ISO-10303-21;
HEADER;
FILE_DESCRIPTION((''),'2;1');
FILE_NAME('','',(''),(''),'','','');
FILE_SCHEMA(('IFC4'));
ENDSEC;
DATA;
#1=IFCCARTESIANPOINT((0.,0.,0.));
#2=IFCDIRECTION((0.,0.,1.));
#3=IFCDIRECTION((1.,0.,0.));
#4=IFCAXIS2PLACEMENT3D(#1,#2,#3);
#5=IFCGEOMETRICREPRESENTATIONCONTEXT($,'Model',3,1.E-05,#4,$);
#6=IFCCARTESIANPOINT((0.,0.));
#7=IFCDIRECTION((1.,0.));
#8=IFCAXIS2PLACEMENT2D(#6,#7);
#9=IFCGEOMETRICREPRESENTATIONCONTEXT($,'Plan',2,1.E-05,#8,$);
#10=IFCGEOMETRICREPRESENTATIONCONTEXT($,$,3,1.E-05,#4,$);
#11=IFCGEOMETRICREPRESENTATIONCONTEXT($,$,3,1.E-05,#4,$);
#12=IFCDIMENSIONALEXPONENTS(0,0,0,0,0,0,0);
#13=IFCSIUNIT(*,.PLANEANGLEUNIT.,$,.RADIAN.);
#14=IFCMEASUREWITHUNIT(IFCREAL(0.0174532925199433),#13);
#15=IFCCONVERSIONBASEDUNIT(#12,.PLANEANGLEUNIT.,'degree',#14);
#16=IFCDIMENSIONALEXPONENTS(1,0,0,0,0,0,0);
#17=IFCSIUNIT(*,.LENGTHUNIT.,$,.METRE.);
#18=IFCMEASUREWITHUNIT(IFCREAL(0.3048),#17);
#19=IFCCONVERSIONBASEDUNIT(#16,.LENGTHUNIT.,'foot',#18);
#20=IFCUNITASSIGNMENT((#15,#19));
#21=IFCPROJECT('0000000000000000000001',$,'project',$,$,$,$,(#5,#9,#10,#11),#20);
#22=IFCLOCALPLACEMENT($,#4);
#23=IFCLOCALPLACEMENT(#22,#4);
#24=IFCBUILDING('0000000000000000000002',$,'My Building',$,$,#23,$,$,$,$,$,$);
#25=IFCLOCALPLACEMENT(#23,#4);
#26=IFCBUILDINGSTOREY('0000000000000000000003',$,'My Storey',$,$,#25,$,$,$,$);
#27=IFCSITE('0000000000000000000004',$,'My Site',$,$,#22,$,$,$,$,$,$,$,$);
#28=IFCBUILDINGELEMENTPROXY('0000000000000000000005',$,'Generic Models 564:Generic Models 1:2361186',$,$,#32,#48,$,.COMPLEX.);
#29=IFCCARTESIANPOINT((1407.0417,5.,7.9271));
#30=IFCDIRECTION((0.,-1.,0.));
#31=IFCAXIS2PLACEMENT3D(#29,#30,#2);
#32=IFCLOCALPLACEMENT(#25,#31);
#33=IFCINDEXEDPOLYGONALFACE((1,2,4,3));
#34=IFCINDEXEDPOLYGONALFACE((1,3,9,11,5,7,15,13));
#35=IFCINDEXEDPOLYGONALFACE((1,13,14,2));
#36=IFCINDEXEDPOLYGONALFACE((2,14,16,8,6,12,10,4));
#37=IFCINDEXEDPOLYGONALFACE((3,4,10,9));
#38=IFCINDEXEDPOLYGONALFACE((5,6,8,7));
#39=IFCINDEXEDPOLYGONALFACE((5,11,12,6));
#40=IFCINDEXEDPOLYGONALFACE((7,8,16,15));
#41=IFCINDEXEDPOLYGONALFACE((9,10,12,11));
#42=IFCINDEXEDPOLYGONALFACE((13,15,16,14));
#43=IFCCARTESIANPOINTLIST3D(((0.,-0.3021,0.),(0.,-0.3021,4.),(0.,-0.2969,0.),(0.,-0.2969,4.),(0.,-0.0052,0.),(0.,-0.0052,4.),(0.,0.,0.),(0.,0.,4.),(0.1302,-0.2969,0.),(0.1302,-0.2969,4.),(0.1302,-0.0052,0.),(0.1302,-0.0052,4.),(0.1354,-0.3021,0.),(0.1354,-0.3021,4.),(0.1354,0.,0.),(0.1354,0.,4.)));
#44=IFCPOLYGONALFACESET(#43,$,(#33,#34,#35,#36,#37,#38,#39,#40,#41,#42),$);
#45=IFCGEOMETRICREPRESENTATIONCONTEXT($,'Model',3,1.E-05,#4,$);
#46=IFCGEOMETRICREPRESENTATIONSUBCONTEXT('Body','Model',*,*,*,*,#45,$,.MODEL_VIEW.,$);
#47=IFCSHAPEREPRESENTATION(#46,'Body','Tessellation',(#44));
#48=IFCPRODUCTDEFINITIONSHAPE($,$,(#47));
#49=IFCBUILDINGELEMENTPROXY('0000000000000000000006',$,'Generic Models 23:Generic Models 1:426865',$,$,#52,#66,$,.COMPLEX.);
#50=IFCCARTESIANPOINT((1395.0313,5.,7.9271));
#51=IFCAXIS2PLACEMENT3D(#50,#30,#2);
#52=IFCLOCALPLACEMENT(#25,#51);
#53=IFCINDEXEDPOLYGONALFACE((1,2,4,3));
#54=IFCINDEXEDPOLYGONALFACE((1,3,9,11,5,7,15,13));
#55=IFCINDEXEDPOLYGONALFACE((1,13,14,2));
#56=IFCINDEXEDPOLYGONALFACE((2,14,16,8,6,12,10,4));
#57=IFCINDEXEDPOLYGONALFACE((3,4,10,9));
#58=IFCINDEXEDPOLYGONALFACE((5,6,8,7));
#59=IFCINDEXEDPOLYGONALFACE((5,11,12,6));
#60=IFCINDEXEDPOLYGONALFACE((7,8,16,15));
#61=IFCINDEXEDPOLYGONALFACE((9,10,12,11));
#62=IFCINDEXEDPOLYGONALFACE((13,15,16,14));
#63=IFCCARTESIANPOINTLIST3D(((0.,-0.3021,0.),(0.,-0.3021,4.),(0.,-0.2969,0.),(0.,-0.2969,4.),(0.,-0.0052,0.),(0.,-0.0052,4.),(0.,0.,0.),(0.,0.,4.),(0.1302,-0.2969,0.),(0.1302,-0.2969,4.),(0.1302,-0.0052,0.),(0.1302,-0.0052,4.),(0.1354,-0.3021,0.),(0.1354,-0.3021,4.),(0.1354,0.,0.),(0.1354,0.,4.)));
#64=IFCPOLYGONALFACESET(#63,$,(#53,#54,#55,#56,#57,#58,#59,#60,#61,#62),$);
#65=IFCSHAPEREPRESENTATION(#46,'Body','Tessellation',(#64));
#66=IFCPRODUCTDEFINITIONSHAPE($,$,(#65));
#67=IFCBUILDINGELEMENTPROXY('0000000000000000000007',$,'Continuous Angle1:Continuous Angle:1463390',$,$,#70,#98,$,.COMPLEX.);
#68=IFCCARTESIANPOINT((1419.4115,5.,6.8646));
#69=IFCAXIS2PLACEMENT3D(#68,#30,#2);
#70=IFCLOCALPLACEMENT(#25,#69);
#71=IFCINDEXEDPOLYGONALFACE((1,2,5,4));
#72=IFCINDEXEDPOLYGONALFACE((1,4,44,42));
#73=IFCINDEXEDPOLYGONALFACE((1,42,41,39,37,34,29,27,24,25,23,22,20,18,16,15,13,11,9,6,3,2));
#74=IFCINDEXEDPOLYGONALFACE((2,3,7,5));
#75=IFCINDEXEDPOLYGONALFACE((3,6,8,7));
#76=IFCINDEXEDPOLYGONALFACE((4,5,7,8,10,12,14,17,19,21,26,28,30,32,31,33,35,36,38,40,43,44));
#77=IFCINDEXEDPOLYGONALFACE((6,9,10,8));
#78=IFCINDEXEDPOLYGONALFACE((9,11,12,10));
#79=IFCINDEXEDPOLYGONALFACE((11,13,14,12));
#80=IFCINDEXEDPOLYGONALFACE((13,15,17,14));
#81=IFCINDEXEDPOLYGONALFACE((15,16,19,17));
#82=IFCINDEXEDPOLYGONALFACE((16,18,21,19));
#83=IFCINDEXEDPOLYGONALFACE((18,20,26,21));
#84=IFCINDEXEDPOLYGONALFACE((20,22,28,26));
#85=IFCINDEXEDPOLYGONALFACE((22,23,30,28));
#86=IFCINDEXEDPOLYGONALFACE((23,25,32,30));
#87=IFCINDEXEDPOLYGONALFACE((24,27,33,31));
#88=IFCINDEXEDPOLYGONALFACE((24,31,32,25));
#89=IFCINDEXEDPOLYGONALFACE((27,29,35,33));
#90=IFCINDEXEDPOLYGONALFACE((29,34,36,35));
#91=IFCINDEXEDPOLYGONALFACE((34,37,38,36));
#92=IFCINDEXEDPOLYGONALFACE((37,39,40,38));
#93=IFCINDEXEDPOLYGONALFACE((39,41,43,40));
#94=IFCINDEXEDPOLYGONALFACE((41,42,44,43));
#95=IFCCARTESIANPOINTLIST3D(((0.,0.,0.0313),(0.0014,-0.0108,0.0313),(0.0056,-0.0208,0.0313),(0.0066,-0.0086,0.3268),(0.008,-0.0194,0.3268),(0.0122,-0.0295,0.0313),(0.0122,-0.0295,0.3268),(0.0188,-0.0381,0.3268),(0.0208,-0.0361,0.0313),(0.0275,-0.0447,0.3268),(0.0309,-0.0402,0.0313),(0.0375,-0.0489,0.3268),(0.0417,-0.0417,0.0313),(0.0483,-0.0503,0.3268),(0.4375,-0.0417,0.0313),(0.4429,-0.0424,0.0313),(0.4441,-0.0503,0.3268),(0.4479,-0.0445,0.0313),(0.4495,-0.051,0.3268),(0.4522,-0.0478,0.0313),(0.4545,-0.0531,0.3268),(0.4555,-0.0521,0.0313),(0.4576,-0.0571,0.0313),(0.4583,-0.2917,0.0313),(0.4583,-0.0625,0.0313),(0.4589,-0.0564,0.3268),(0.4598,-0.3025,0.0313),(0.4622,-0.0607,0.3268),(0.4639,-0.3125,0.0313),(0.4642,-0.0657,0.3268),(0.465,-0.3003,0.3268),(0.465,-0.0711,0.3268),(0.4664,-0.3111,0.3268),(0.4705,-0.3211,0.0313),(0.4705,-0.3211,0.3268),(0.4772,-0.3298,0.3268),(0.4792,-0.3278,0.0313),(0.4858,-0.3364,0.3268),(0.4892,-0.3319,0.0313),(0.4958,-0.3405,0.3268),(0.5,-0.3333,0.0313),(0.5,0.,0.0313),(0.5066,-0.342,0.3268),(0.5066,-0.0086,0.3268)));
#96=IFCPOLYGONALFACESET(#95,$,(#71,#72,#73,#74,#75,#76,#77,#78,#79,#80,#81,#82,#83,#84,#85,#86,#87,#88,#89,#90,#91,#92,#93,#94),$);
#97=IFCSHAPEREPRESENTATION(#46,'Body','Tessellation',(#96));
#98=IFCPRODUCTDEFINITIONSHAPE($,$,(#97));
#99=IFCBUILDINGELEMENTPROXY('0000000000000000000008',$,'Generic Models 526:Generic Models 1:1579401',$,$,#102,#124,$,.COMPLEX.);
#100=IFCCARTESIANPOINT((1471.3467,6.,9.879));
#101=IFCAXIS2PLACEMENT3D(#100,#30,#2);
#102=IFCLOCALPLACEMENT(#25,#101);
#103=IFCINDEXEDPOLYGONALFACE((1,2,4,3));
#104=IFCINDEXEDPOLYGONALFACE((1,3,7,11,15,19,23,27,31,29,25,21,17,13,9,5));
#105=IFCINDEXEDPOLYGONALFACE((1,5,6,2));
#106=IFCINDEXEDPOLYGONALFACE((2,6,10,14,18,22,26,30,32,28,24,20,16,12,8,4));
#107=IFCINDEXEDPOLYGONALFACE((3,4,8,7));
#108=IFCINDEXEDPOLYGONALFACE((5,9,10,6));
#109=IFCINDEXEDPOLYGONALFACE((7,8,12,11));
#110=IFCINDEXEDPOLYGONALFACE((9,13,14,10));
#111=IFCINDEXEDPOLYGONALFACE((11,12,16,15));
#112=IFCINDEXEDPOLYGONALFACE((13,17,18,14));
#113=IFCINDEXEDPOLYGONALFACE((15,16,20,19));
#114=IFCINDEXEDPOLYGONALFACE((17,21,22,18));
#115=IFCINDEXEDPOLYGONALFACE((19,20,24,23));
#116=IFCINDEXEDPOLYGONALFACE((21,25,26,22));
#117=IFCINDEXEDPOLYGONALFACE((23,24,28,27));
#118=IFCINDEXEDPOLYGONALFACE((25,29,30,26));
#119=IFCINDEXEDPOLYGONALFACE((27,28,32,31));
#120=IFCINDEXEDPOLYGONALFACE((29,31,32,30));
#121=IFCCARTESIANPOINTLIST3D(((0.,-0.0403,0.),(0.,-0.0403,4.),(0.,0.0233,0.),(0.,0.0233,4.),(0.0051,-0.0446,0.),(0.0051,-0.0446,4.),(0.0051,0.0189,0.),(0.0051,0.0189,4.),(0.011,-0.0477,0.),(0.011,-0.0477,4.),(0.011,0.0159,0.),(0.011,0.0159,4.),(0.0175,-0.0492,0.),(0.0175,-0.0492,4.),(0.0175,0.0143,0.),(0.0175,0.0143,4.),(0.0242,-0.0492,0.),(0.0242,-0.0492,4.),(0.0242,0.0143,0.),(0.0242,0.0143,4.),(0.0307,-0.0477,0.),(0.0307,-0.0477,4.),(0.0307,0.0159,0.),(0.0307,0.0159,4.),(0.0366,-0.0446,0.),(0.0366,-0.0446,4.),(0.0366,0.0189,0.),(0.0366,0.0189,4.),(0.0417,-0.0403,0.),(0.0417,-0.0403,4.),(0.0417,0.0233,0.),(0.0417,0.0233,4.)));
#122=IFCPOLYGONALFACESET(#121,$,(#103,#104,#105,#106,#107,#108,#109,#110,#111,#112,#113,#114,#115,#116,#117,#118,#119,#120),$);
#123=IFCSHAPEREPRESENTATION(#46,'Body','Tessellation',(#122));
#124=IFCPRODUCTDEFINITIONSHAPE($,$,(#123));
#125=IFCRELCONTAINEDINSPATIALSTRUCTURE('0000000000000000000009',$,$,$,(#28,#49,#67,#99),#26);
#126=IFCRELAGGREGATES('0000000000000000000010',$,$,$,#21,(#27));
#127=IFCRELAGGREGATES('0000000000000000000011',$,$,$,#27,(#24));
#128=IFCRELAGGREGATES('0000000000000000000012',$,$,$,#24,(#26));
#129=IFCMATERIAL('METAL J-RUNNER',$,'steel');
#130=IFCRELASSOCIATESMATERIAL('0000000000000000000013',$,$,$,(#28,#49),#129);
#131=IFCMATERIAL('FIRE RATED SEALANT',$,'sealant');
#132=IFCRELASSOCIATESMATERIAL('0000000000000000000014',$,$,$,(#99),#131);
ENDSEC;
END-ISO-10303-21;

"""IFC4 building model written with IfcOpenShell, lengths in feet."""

from ifc_helpers import new_model, entity, si_unit, converted_unit, frame, origin_with_axes, origin_2d_with_axis, place, context, subcontext, project, spatial, polyline, line, indexed_curve, outline, extrude, material, element, save


model = new_model("IFC4")

# Units and contexts
model_context_1 = context("Model", 3, precision=1e-05, world=origin_with_axes())
plan_context = context("Plan", 2, precision=1e-05, world=origin_2d_with_axis())
model_context_2 = context("Model", 3, precision=1e-05, world=origin_with_axes())
context_of_model_1 = context(None, 3, precision=1e-05, world=origin_with_axes())
context_of_model_2 = context(None, 3, precision=1e-05, world=origin_with_axes())
body_context_1 = subcontext(model_context_2, "Body", "Model", "MODEL_VIEW")
ifc_project = project(units=[converted_unit("PLANEANGLEUNIT", "degree", entity("IfcReal", 0.0174532925199433), si_unit("PLANEANGLEUNIT", "RADIAN"), dimensions=[0, 0, 0, 0, 0, 0, 0]), converted_unit("LENGTHUNIT", "foot", entity("IfcReal", 0.3048), si_unit("LENGTHUNIT", "METRE"), dimensions=[1, 0, 0, 0, 0, 0, 0])], contexts=[model_context_1, plan_context, context_of_model_1, context_of_model_2])

# Site, building, storey
site_placement = place(None, origin_with_axes())
site = spatial("IfcSite", under=ifc_project, at=site_placement, Name="My Site")
building_placement = place(site_placement, origin_with_axes())
building = spatial("IfcBuilding", under=site, at=building_placement, Name="My Building")
storey_placement = place(building_placement, origin_with_axes())
storey = spatial("IfcBuildingStorey", under=building, at=storey_placement, Name="My Storey")

# Building element proxies
ifc_material_1 = material(Name="METAL J-RUNNER", Category="steel")
proxy_1_placement = place(storey_placement, frame((1407.0417, 5.0, 7.9271), z_axis=(0.0, -1.0, 0.0), x_axis=(0.0, 0.0, 1.0)))
element("IfcBuildingElementProxy", 1, at=proxy_1_placement, inside=storey, material=ifc_material_1, Name="Generic Models 564:Generic Models 1:2361186", PredefinedType="COMPLEX", context=body_context_1, shape_type="SweptSolid", body=[
    extrude(outline(polyline([(-0.069, -0.151), (0.0664, -0.151), (0.0664, -0.1458), (-0.0638, -0.1458), (-0.0638, 0.1458), (0.0664, 0.1458), (0.0664, 0.151), (-0.069, 0.151), (-0.069, -0.151)])), frame((0.0664, -0.151, 0.0), z_axis=(0.0, 0.0, -1.0), x_axis=(-1.0, 0.0, 0.0)), (0.0, 0.0, -1.0), 4.0),
])
proxy_2_placement = place(storey_placement, frame((1395.0313, 5.0, 7.9271), z_axis=(0.0, -1.0, 0.0), x_axis=(0.0, 0.0, 1.0)))
element("IfcBuildingElementProxy", 2, at=proxy_2_placement, inside=storey, material=ifc_material_1, Name="Generic Models 23:Generic Models 1:426865", PredefinedType="COMPLEX", context=body_context_1, shape_type="SweptSolid", body=[
    extrude(outline(polyline([(-0.0638, 0.1458), (0.0664, 0.1458), (0.0664, 0.151), (-0.069, 0.151), (-0.069, -0.151), (0.0664, -0.151), (0.0664, -0.1458), (-0.0638, -0.1458), (-0.0638, 0.1458)])), frame((0.0664, -0.151, 0.0), z_axis=(0.0, 0.0, -1.0), x_axis=(-1.0, 0.0, 0.0)), (0.0, 0.0, -1.0), 4.0),
])
proxy_3_placement = place(storey_placement, frame((1419.4115, 5.0, 6.8646), z_axis=(0.0, -1.0, 0.0), x_axis=(0.0, 0.0, 1.0)))
element("IfcBuildingElementProxy", 3, at=proxy_3_placement, inside=storey, Name="Continuous Angle1:Continuous Angle:1463390", PredefinedType="COMPLEX", context=body_context_1, shape_type="SweptSolid", body=[
    extrude(outline(polyline([(0.2352, 0.0), (0.2247, -0.0027), (0.2152, -0.0081), (0.0324, -0.1463), (0.0277, -0.149), (0.0224, -0.1504), (0.017, -0.1503), (0.0117, -0.1489), (0.007, -0.1461), (0.0032, -0.1423), (-0.2355, 0.1735), (-0.2431, 0.1812), (-0.2525, 0.1867), (-0.263, 0.1896), (-0.2739, 0.1897), (-0.2844, 0.1869), (-0.2939, 0.1816), (0.0077, -0.2173), (0.2736, -0.0162), (0.2659, -0.0085), (0.2566, -0.003), (0.2461, -0.0001), (0.2352, 0.0)])), frame((0.3221, -0.1249, 0.0313), z_axis=(0.0, 0.0, -1.0), x_axis=(0.60311, -0.797658, 0.0)), (0.036779, -0.000261, -0.999323), 0.2957),
])
ifc_material_2 = material(Name="FIRE RATED SEALANT", Category="sealant")
proxy_4_placement = place(storey_placement, frame((1471.3467, 6.0, 9.879), z_axis=(0.0, -1.0, 0.0), x_axis=(0.0, 0.0, 1.0)))
element("IfcBuildingElementProxy", 4, at=proxy_4_placement, inside=storey, material=ifc_material_2, Name="Generic Models 526:Generic Models 1:1579401", PredefinedType="COMPLEX", context=body_context_1, shape_type="SweptSolid", body=[
    extrude(outline(indexed_curve([(-0.0265, 0.0234), (-0.0323, 0.0201), (-0.0387, 0.0182), (-0.0454, 0.0179), (-0.0019, -0.0284), (0.0048, -0.0281), (0.0112, -0.0263), (0.017, -0.023), (0.0219, -0.0184), (0.0255, -0.0128), (0.0278, -0.0065), (0.0285, 0.0001), (-0.015, 0.0464), (-0.0157, 0.0398), (-0.018, 0.0335), (-0.0216, 0.0279)], segments=[line(2, 1), line(1, 16), line(16, 15), line(15, 14), line(14, 13), line(13, 12), line(12, 11), line(11, 10), line(10, 9), line(9, 8), line(8, 7), line(7, 6), line(6, 5), line(5, 4), line(4, 3), line(3, 2)], self_intersect=False)), frame((0.0208, -0.0208, 0.0), z_axis=(0.0, 0.0, -1.0), x_axis=(-0.729168, -0.684334, 0.0)), (0.0, 0.0, -1.0), 4.0),
])

save(model, "model.ifc")
